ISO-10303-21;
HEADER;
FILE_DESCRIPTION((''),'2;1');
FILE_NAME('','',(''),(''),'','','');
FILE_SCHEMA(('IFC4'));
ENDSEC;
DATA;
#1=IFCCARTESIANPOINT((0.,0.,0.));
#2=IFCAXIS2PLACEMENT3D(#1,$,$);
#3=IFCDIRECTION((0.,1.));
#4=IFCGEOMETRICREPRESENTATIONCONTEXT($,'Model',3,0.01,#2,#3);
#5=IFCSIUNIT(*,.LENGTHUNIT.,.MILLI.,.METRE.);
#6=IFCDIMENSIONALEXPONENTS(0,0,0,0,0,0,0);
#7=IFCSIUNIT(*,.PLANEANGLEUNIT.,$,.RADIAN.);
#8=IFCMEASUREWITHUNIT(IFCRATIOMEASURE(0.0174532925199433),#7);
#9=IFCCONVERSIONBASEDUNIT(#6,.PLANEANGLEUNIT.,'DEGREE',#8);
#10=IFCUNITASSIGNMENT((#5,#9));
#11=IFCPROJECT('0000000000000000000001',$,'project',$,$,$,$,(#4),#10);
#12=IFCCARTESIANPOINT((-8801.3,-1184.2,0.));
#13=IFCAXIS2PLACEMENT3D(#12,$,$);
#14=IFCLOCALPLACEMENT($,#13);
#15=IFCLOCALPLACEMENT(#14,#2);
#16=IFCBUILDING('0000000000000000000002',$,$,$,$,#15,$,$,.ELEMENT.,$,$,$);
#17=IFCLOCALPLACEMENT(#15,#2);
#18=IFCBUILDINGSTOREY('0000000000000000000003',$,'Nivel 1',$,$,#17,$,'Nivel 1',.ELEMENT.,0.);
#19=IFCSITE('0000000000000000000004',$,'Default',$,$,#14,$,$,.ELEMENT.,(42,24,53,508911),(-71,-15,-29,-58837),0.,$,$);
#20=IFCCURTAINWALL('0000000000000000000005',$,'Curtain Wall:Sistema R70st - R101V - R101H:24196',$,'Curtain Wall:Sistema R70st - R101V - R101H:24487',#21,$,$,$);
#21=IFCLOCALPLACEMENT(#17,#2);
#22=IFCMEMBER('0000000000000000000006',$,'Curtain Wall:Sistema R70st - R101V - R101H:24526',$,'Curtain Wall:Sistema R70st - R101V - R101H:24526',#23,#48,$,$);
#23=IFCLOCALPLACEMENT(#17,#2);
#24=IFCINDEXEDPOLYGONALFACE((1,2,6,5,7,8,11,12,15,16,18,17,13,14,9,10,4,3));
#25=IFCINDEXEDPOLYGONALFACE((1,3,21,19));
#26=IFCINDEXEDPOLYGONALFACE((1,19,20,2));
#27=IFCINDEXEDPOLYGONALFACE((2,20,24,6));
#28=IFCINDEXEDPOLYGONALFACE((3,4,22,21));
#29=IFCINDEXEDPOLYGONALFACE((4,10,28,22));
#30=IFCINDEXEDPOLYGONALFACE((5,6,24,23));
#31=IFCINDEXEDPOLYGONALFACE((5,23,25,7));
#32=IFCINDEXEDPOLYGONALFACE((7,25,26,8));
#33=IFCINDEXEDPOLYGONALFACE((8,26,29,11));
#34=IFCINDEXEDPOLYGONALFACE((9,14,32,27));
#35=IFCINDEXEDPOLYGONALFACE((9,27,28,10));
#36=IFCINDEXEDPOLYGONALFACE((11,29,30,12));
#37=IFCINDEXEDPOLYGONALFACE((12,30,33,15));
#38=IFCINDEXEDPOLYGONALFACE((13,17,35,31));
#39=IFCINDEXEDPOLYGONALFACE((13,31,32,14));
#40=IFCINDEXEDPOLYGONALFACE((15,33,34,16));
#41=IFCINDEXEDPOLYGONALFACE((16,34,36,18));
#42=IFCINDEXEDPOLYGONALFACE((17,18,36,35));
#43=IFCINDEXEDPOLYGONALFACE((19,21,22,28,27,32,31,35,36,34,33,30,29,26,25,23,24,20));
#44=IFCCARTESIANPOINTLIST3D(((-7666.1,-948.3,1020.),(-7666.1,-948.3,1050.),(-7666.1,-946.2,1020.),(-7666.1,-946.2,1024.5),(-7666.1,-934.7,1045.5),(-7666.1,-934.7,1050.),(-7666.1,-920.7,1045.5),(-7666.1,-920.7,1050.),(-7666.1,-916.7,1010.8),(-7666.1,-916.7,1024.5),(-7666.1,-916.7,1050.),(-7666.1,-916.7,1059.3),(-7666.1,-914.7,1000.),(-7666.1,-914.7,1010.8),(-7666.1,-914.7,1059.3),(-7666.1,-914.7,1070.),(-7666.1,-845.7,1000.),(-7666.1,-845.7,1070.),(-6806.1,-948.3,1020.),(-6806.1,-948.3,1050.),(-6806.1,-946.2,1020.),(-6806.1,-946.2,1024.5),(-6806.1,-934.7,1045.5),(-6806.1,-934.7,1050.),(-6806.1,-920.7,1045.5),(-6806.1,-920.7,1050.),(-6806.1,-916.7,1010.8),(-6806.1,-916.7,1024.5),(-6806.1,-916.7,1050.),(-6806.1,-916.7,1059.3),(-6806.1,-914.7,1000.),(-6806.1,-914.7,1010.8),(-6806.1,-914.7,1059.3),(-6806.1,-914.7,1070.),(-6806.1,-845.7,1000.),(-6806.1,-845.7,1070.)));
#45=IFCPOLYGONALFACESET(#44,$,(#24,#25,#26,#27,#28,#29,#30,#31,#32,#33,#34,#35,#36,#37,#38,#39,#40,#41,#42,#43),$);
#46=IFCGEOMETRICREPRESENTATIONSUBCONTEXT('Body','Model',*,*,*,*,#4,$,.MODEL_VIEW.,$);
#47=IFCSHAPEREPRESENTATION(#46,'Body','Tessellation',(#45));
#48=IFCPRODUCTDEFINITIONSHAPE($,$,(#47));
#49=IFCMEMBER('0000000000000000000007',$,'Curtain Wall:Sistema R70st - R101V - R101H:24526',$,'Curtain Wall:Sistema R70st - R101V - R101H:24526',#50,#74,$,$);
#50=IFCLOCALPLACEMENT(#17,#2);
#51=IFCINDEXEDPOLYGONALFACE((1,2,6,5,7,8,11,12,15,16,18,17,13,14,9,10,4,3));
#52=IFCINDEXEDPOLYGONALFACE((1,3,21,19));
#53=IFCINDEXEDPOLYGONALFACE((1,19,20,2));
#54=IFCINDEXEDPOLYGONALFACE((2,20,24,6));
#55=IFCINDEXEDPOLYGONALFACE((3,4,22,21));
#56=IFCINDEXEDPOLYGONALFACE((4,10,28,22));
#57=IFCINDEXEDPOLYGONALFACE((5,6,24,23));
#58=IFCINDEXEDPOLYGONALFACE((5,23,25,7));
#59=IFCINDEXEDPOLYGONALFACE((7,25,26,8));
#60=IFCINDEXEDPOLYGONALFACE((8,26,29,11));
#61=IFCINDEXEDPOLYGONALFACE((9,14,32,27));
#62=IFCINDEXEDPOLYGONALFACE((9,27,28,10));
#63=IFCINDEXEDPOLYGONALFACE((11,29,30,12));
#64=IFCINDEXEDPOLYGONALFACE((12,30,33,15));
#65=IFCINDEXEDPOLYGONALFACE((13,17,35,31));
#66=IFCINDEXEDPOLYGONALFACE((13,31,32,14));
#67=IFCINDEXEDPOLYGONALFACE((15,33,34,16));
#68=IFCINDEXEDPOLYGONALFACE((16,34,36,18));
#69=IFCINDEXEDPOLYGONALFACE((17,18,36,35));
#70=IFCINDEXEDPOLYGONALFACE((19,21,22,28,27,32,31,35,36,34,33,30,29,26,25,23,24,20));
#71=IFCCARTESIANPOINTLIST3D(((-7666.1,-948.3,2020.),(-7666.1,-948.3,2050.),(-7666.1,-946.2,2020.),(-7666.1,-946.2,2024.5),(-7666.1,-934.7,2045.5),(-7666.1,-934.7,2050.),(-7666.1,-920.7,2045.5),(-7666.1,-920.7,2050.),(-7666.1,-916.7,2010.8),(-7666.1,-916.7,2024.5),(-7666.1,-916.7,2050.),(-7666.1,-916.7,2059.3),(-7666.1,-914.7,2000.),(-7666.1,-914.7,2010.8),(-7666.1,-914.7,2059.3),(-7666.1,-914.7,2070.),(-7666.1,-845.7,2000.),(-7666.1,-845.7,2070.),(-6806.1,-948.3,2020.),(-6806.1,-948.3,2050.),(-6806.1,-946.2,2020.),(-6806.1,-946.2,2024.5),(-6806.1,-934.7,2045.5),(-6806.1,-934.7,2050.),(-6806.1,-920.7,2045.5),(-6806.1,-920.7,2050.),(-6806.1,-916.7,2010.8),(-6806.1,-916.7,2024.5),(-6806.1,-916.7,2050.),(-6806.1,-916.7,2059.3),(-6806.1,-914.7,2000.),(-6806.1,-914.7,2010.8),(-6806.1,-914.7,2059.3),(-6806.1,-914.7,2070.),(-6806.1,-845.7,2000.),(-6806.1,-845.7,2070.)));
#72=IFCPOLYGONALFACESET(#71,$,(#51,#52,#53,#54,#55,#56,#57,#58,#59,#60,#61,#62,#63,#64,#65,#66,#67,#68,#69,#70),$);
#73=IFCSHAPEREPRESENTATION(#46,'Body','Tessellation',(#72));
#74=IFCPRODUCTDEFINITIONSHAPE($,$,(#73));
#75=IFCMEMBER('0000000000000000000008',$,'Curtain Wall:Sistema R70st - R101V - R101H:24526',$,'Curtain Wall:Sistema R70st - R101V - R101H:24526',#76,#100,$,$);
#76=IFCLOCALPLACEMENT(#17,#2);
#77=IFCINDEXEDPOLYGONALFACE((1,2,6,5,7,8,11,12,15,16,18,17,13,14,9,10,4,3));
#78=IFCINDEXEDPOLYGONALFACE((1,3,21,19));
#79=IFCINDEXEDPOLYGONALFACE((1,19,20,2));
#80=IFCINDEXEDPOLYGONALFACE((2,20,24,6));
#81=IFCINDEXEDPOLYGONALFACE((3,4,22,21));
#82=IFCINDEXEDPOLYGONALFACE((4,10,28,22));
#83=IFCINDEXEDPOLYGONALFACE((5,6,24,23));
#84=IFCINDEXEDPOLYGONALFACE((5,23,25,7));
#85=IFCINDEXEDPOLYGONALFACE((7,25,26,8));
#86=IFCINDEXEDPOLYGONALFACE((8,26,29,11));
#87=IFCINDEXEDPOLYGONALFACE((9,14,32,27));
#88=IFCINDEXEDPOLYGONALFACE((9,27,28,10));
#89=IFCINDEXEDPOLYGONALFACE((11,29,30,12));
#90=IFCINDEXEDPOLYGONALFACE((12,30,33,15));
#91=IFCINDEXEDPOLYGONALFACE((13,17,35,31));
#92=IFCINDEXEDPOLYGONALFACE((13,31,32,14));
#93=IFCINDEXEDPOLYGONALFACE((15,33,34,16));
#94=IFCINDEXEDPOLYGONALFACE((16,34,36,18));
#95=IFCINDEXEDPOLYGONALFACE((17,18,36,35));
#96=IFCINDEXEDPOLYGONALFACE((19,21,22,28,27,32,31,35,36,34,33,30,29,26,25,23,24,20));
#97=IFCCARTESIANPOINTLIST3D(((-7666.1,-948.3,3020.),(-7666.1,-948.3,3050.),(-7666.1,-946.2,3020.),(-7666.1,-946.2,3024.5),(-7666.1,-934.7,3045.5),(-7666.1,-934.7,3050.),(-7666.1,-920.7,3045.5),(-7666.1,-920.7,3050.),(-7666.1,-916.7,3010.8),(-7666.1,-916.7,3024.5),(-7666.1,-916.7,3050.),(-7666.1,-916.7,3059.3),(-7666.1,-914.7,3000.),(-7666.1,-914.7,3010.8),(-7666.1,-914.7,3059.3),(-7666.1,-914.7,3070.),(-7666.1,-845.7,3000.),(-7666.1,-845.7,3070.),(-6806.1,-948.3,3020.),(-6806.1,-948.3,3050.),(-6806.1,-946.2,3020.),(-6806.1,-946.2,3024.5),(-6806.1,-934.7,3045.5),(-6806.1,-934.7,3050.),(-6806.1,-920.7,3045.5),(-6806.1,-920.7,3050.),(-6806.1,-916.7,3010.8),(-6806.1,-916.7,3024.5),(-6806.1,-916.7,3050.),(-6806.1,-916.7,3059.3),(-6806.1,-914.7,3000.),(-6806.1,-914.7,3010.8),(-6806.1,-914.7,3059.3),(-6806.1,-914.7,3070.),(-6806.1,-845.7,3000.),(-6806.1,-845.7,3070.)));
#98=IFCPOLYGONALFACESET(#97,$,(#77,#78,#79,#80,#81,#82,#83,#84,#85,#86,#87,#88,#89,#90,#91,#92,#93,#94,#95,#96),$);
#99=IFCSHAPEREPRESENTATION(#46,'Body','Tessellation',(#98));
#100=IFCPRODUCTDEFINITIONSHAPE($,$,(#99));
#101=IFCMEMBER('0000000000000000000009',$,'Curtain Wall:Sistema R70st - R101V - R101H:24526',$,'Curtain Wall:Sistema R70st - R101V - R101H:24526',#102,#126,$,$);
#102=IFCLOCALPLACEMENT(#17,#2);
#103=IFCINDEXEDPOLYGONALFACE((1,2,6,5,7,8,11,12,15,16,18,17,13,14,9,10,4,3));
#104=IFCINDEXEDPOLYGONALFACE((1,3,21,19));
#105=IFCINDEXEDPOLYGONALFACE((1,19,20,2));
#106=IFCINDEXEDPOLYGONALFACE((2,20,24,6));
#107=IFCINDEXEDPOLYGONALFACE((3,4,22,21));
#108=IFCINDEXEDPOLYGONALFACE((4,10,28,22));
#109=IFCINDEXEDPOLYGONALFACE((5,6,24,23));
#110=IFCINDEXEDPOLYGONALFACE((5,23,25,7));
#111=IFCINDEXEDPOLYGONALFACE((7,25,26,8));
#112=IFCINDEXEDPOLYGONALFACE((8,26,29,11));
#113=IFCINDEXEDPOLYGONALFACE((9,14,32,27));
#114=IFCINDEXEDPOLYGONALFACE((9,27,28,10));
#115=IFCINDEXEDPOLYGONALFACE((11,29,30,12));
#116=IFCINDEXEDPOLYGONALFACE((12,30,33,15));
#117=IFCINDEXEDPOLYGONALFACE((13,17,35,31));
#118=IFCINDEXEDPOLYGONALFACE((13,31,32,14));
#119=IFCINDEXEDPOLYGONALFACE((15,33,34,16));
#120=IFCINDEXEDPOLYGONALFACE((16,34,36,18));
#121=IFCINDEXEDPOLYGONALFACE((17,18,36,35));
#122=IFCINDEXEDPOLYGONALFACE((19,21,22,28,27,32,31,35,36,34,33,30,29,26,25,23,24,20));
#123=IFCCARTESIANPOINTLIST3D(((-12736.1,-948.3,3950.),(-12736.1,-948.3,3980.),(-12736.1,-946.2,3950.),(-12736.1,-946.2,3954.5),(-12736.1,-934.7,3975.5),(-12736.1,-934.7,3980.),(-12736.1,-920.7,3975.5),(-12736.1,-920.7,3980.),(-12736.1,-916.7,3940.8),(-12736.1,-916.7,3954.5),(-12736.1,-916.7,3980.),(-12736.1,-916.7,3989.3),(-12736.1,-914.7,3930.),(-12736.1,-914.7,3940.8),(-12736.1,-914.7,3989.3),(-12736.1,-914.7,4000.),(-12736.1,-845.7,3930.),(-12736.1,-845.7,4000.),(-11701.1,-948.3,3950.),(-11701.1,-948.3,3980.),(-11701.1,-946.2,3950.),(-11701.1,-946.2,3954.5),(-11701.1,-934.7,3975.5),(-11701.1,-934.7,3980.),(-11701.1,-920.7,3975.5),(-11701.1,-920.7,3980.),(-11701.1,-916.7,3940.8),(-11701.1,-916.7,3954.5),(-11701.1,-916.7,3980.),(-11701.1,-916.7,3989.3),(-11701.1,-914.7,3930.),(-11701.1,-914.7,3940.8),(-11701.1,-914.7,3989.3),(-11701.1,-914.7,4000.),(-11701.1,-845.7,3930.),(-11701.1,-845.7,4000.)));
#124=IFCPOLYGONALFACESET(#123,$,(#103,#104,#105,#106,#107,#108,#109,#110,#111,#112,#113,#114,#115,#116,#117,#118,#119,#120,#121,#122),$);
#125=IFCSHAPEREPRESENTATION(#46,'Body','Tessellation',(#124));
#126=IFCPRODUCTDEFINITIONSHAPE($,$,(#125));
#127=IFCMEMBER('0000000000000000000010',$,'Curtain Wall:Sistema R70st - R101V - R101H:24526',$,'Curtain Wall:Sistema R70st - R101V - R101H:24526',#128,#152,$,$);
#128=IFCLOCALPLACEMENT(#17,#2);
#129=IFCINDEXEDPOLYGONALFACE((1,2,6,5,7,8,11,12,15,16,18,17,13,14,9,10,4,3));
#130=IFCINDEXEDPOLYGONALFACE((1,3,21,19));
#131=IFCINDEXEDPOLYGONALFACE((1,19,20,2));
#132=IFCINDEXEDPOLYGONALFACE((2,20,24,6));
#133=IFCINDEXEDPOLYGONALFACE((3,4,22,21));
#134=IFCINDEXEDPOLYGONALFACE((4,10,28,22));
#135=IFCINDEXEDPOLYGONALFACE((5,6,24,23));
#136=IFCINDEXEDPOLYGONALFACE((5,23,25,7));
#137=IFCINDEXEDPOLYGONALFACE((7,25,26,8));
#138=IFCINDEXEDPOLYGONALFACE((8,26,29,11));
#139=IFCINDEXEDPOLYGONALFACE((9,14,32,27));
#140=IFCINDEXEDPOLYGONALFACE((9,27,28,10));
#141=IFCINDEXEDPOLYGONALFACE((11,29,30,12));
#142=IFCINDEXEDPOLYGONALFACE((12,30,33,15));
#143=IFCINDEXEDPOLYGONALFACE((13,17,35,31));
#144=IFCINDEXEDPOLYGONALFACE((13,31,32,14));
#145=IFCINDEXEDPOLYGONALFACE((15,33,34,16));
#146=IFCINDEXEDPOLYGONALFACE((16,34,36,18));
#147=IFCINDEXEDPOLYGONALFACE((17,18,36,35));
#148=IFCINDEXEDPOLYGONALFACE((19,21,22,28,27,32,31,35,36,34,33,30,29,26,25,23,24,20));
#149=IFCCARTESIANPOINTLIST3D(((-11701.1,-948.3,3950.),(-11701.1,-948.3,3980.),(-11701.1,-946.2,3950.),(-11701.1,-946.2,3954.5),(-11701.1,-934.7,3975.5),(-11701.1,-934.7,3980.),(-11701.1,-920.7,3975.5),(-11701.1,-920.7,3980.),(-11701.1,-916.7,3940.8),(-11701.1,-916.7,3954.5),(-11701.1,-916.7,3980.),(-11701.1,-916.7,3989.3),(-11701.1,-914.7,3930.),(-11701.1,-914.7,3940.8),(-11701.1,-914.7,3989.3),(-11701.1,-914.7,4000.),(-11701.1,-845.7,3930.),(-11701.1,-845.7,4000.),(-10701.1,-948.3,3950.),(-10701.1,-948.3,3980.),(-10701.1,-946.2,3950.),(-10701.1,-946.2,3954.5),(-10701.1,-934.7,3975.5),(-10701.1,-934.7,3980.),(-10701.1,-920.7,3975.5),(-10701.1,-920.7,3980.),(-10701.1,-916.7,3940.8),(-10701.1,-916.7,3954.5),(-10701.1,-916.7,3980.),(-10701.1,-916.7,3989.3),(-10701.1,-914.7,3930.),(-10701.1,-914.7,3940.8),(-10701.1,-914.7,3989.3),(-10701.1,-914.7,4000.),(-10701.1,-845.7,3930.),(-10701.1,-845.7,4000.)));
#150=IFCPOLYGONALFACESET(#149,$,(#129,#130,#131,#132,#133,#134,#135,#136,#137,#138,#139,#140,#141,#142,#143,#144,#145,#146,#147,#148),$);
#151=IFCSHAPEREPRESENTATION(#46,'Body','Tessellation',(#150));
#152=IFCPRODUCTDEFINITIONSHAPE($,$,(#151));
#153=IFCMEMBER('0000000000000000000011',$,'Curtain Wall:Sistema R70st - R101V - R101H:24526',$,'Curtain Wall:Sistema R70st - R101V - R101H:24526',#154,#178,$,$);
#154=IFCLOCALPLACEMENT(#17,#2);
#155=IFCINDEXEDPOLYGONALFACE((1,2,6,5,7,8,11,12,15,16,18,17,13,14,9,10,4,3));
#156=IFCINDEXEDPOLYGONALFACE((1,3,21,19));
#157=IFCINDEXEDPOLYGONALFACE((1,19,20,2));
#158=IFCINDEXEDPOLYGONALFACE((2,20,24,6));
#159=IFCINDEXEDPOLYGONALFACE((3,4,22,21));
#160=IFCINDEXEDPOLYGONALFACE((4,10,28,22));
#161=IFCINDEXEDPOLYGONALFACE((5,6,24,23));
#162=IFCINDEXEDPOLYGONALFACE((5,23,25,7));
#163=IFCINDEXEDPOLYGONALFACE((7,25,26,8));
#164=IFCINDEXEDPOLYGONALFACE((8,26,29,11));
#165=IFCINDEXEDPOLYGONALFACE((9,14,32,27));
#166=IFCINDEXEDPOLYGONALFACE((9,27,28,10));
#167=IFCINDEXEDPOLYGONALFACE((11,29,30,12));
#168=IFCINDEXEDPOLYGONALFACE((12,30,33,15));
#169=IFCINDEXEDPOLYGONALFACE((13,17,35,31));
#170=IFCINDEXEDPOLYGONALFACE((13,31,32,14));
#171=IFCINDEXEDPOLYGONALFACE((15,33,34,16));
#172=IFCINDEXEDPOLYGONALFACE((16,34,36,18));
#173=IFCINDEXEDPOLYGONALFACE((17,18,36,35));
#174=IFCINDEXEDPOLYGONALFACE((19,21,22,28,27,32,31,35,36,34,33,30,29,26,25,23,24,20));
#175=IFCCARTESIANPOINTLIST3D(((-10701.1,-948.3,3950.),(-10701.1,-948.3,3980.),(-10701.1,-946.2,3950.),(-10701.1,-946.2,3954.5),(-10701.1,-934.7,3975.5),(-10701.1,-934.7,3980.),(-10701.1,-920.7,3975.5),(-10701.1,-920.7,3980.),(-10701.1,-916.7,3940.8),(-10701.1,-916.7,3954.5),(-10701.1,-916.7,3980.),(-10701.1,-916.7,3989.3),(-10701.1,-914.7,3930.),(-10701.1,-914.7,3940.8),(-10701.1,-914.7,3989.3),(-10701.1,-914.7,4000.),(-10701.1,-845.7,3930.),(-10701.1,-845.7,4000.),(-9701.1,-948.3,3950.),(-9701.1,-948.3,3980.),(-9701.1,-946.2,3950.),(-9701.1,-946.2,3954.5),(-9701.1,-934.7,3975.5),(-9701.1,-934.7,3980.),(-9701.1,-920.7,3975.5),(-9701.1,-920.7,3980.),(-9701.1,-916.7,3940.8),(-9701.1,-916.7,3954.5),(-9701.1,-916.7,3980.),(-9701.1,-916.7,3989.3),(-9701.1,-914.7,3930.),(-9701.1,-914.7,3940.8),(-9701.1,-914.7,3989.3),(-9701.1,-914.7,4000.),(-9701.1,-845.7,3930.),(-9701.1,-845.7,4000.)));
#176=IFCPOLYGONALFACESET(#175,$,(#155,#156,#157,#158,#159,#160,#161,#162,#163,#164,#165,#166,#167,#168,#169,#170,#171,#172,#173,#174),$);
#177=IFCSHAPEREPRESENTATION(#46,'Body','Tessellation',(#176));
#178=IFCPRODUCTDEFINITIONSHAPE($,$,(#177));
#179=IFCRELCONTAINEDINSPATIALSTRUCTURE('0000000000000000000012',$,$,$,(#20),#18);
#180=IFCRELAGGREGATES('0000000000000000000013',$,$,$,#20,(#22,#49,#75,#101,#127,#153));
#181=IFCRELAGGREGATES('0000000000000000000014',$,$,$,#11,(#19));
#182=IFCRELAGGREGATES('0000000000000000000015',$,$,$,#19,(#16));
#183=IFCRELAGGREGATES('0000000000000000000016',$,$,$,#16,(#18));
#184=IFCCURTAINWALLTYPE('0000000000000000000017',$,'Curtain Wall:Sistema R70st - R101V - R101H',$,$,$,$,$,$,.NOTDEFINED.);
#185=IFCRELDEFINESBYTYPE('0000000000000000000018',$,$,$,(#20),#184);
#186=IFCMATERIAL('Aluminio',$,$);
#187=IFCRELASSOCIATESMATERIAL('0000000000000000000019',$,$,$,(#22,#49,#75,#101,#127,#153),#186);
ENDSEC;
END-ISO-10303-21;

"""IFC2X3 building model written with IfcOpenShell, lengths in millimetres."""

from ifc_helpers import new_model, entity, si_unit, converted_unit, direction, frame, origin, place, context, subcontext, project, spatial, polyline, outline, extrude, material, type_object, element, aggregate, save


model = new_model("IFC2X3")

# Units and contexts
model_context = context("Model", 3, precision=0.01, world=origin(), true_north=direction((0.0, 1.0)))
body_context = subcontext(model_context, "Body", "Model", "MODEL_VIEW")
ifc_project = project(units=[si_unit("LENGTHUNIT", "METRE", prefix="MILLI"), converted_unit("PLANEANGLEUNIT", "DEGREE", entity("IfcRatioMeasure", 0.0174532925199433), si_unit("PLANEANGLEUNIT", "RADIAN"), dimensions=[0, 0, 0, 0, 0, 0, 0])], contexts=[model_context])

# Site, building, storey
site_placement = place(None, frame((-8801.3, -1184.2, 0.0)))
site = spatial("IfcSite", under=ifc_project, at=site_placement, Name="Default", CompositionType="ELEMENT", RefLatitude=(42, 24, 53, 508911), RefLongitude=(-71, -15, -29, -58837), RefElevation=0.0)
building_placement = place(site_placement, origin())
building = spatial("IfcBuilding", under=site, at=building_placement, CompositionType="ELEMENT")
storey_placement = place(building_placement, origin())
storey = spatial("IfcBuildingStorey", under=building, at=storey_placement, Name="Nivel 1", LongName="Nivel 1", CompositionType="ELEMENT", Elevation=0.0)

# Curtain wall, members
curtain_wall_type = type_object("IfcCurtainWallType", Name="Curtain Wall:Sistema R70st - R101V - R101H", PredefinedType="NOTDEFINED")
curtain_wall_placement = place(storey_placement, origin())
curtain_wall = element("IfcCurtainWall", 1, at=curtain_wall_placement, inside=storey, type_object=curtain_wall_type, Name="Curtain Wall:Sistema R70st - R101V - R101H:24196", ObjectType="Curtain Wall:Sistema R70st - R101V - R101H:24487")
ifc_material = material(Name="Aluminio")
member_1_placement = place(curtain_wall_placement, origin())
member_1 = element("IfcMember", 2, at=member_1_placement, material=ifc_material, Name="Curtain Wall:Sistema R70st - R101V - R101H:24526", ObjectType="Curtain Wall:Sistema R70st - R101V - R101H:24526", context=body_context, shape_type="SweptSolid", body=[
    extrude(outline(polyline([(-33.3, -71.9), (36.7, -71.9), (36.7, -2.9), (25.9, -2.9), (25.9, -0.9), (12.2, -0.9), (12.2, 28.6), (16.7, 28.6), (16.7, 30.7), (-13.3, 30.7), (-13.3, 17.1), (-8.8, 17.1), (-8.8, 3.1), (-13.3, 3.1), (-13.3, -0.9), (-22.6, -0.9), (-22.6, -2.9), (-33.3, -2.9), (-33.3, -71.9)])), frame((-6806.1, -917.6, 1036.7), z_axis=(-1.0, 0.0, 0.0), x_axis=(0.0, 0.0, -1.0)), (0.0, 0.0, 1.0), 860.0),
])
member_2_placement = place(curtain_wall_placement, origin())
member_2 = element("IfcMember", 3, at=member_2_placement, material=ifc_material, Name="Curtain Wall:Sistema R70st - R101V - R101H:24526", ObjectType="Curtain Wall:Sistema R70st - R101V - R101H:24526", context=body_context, shape_type="SweptSolid", body=[
    extrude(outline(polyline([(-33.3, -71.9), (36.7, -71.9), (36.7, -2.9), (25.9, -2.9), (25.9, -0.9), (12.2, -0.9), (12.2, 28.6), (16.7, 28.6), (16.7, 30.7), (-13.3, 30.7), (-13.3, 17.1), (-8.8, 17.1), (-8.8, 3.1), (-13.3, 3.1), (-13.3, -0.9), (-22.6, -0.9), (-22.6, -2.9), (-33.3, -2.9), (-33.3, -71.9)])), frame((-6806.1, -917.6, 2036.7), z_axis=(-1.0, 0.0, 0.0), x_axis=(0.0, 0.0, -1.0)), (0.0, 0.0, 1.0), 860.0),
])
member_3_placement = place(curtain_wall_placement, origin())
member_3 = element("IfcMember", 4, at=member_3_placement, material=ifc_material, Name="Curtain Wall:Sistema R70st - R101V - R101H:24526", ObjectType="Curtain Wall:Sistema R70st - R101V - R101H:24526", context=body_context, shape_type="SweptSolid", body=[
    extrude(outline(polyline([(-33.3, -71.9), (36.7, -71.9), (36.7, -2.9), (25.9, -2.9), (25.9, -0.9), (12.2, -0.9), (12.2, 28.6), (16.7, 28.6), (16.7, 30.7), (-13.3, 30.7), (-13.3, 17.1), (-8.8, 17.1), (-8.8, 3.1), (-13.3, 3.1), (-13.3, -0.9), (-22.6, -0.9), (-22.6, -2.9), (-33.3, -2.9), (-33.3, -71.9)])), frame((-6806.1, -917.6, 3036.7), z_axis=(-1.0, 0.0, 0.0), x_axis=(0.0, 0.0, -1.0)), (0.0, 0.0, 1.0), 860.0),
])
member_4_placement = place(curtain_wall_placement, origin())
member_4 = element("IfcMember", 5, at=member_4_placement, material=ifc_material, Name="Curtain Wall:Sistema R70st - R101V - R101H:24526", ObjectType="Curtain Wall:Sistema R70st - R101V - R101H:24526", context=body_context, shape_type="SweptSolid", body=[
    extrude(outline(polyline([(-33.3, -71.9), (36.7, -71.9), (36.7, -2.9), (25.9, -2.9), (25.9, -0.9), (12.2, -0.9), (12.2, 28.6), (16.7, 28.6), (16.7, 30.7), (-13.3, 30.7), (-13.3, 17.1), (-8.8, 17.1), (-8.8, 3.1), (-13.3, 3.1), (-13.3, -0.9), (-22.6, -0.9), (-22.6, -2.9), (-33.3, -2.9), (-33.3, -71.9)])), frame((-11701.1, -917.6, 3966.7), z_axis=(-1.0, 0.0, 0.0), x_axis=(0.0, 0.0, -1.0)), (0.0, 0.0, 1.0), 1035.0),
])
member_5_placement = place(curtain_wall_placement, origin())
member_5 = element("IfcMember", 6, at=member_5_placement, material=ifc_material, Name="Curtain Wall:Sistema R70st - R101V - R101H:24526", ObjectType="Curtain Wall:Sistema R70st - R101V - R101H:24526", context=body_context, shape_type="SweptSolid", body=[
    extrude(outline(polyline([(-33.3, -71.9), (36.7, -71.9), (36.7, -2.9), (25.9, -2.9), (25.9, -0.9), (12.2, -0.9), (12.2, 28.6), (16.7, 28.6), (16.7, 30.7), (-13.3, 30.7), (-13.3, 17.1), (-8.8, 17.1), (-8.8, 3.1), (-13.3, 3.1), (-13.3, -0.9), (-22.6, -0.9), (-22.6, -2.9), (-33.3, -2.9), (-33.3, -71.9)])), frame((-10701.1, -917.6, 3966.7), z_axis=(-1.0, 0.0, 0.0), x_axis=(0.0, 0.0, -1.0)), (0.0, 0.0, 1.0), 1000.0),
])
member_6_placement = place(curtain_wall_placement, origin())
member_6 = element("IfcMember", 7, at=member_6_placement, material=ifc_material, Name="Curtain Wall:Sistema R70st - R101V - R101H:24526", ObjectType="Curtain Wall:Sistema R70st - R101V - R101H:24526", context=body_context, shape_type="SweptSolid", body=[
    extrude(outline(polyline([(-33.3, -71.9), (36.7, -71.9), (36.7, -2.9), (25.9, -2.9), (25.9, -0.9), (12.2, -0.9), (12.2, 28.6), (16.7, 28.6), (16.7, 30.7), (-13.3, 30.7), (-13.3, 17.1), (-8.8, 17.1), (-8.8, 3.1), (-13.3, 3.1), (-13.3, -0.9), (-22.6, -0.9), (-22.6, -2.9), (-33.3, -2.9), (-33.3, -71.9)])), frame((-9701.1, -917.6, 3966.7), z_axis=(-1.0, 0.0, 0.0), x_axis=(0.0, 0.0, -1.0)), (0.0, 0.0, 1.0), 1000.0),
])
aggregate(curtain_wall, [member_1, member_2, member_3, member_4, member_5, member_6])

save(model, "model.ifc")
